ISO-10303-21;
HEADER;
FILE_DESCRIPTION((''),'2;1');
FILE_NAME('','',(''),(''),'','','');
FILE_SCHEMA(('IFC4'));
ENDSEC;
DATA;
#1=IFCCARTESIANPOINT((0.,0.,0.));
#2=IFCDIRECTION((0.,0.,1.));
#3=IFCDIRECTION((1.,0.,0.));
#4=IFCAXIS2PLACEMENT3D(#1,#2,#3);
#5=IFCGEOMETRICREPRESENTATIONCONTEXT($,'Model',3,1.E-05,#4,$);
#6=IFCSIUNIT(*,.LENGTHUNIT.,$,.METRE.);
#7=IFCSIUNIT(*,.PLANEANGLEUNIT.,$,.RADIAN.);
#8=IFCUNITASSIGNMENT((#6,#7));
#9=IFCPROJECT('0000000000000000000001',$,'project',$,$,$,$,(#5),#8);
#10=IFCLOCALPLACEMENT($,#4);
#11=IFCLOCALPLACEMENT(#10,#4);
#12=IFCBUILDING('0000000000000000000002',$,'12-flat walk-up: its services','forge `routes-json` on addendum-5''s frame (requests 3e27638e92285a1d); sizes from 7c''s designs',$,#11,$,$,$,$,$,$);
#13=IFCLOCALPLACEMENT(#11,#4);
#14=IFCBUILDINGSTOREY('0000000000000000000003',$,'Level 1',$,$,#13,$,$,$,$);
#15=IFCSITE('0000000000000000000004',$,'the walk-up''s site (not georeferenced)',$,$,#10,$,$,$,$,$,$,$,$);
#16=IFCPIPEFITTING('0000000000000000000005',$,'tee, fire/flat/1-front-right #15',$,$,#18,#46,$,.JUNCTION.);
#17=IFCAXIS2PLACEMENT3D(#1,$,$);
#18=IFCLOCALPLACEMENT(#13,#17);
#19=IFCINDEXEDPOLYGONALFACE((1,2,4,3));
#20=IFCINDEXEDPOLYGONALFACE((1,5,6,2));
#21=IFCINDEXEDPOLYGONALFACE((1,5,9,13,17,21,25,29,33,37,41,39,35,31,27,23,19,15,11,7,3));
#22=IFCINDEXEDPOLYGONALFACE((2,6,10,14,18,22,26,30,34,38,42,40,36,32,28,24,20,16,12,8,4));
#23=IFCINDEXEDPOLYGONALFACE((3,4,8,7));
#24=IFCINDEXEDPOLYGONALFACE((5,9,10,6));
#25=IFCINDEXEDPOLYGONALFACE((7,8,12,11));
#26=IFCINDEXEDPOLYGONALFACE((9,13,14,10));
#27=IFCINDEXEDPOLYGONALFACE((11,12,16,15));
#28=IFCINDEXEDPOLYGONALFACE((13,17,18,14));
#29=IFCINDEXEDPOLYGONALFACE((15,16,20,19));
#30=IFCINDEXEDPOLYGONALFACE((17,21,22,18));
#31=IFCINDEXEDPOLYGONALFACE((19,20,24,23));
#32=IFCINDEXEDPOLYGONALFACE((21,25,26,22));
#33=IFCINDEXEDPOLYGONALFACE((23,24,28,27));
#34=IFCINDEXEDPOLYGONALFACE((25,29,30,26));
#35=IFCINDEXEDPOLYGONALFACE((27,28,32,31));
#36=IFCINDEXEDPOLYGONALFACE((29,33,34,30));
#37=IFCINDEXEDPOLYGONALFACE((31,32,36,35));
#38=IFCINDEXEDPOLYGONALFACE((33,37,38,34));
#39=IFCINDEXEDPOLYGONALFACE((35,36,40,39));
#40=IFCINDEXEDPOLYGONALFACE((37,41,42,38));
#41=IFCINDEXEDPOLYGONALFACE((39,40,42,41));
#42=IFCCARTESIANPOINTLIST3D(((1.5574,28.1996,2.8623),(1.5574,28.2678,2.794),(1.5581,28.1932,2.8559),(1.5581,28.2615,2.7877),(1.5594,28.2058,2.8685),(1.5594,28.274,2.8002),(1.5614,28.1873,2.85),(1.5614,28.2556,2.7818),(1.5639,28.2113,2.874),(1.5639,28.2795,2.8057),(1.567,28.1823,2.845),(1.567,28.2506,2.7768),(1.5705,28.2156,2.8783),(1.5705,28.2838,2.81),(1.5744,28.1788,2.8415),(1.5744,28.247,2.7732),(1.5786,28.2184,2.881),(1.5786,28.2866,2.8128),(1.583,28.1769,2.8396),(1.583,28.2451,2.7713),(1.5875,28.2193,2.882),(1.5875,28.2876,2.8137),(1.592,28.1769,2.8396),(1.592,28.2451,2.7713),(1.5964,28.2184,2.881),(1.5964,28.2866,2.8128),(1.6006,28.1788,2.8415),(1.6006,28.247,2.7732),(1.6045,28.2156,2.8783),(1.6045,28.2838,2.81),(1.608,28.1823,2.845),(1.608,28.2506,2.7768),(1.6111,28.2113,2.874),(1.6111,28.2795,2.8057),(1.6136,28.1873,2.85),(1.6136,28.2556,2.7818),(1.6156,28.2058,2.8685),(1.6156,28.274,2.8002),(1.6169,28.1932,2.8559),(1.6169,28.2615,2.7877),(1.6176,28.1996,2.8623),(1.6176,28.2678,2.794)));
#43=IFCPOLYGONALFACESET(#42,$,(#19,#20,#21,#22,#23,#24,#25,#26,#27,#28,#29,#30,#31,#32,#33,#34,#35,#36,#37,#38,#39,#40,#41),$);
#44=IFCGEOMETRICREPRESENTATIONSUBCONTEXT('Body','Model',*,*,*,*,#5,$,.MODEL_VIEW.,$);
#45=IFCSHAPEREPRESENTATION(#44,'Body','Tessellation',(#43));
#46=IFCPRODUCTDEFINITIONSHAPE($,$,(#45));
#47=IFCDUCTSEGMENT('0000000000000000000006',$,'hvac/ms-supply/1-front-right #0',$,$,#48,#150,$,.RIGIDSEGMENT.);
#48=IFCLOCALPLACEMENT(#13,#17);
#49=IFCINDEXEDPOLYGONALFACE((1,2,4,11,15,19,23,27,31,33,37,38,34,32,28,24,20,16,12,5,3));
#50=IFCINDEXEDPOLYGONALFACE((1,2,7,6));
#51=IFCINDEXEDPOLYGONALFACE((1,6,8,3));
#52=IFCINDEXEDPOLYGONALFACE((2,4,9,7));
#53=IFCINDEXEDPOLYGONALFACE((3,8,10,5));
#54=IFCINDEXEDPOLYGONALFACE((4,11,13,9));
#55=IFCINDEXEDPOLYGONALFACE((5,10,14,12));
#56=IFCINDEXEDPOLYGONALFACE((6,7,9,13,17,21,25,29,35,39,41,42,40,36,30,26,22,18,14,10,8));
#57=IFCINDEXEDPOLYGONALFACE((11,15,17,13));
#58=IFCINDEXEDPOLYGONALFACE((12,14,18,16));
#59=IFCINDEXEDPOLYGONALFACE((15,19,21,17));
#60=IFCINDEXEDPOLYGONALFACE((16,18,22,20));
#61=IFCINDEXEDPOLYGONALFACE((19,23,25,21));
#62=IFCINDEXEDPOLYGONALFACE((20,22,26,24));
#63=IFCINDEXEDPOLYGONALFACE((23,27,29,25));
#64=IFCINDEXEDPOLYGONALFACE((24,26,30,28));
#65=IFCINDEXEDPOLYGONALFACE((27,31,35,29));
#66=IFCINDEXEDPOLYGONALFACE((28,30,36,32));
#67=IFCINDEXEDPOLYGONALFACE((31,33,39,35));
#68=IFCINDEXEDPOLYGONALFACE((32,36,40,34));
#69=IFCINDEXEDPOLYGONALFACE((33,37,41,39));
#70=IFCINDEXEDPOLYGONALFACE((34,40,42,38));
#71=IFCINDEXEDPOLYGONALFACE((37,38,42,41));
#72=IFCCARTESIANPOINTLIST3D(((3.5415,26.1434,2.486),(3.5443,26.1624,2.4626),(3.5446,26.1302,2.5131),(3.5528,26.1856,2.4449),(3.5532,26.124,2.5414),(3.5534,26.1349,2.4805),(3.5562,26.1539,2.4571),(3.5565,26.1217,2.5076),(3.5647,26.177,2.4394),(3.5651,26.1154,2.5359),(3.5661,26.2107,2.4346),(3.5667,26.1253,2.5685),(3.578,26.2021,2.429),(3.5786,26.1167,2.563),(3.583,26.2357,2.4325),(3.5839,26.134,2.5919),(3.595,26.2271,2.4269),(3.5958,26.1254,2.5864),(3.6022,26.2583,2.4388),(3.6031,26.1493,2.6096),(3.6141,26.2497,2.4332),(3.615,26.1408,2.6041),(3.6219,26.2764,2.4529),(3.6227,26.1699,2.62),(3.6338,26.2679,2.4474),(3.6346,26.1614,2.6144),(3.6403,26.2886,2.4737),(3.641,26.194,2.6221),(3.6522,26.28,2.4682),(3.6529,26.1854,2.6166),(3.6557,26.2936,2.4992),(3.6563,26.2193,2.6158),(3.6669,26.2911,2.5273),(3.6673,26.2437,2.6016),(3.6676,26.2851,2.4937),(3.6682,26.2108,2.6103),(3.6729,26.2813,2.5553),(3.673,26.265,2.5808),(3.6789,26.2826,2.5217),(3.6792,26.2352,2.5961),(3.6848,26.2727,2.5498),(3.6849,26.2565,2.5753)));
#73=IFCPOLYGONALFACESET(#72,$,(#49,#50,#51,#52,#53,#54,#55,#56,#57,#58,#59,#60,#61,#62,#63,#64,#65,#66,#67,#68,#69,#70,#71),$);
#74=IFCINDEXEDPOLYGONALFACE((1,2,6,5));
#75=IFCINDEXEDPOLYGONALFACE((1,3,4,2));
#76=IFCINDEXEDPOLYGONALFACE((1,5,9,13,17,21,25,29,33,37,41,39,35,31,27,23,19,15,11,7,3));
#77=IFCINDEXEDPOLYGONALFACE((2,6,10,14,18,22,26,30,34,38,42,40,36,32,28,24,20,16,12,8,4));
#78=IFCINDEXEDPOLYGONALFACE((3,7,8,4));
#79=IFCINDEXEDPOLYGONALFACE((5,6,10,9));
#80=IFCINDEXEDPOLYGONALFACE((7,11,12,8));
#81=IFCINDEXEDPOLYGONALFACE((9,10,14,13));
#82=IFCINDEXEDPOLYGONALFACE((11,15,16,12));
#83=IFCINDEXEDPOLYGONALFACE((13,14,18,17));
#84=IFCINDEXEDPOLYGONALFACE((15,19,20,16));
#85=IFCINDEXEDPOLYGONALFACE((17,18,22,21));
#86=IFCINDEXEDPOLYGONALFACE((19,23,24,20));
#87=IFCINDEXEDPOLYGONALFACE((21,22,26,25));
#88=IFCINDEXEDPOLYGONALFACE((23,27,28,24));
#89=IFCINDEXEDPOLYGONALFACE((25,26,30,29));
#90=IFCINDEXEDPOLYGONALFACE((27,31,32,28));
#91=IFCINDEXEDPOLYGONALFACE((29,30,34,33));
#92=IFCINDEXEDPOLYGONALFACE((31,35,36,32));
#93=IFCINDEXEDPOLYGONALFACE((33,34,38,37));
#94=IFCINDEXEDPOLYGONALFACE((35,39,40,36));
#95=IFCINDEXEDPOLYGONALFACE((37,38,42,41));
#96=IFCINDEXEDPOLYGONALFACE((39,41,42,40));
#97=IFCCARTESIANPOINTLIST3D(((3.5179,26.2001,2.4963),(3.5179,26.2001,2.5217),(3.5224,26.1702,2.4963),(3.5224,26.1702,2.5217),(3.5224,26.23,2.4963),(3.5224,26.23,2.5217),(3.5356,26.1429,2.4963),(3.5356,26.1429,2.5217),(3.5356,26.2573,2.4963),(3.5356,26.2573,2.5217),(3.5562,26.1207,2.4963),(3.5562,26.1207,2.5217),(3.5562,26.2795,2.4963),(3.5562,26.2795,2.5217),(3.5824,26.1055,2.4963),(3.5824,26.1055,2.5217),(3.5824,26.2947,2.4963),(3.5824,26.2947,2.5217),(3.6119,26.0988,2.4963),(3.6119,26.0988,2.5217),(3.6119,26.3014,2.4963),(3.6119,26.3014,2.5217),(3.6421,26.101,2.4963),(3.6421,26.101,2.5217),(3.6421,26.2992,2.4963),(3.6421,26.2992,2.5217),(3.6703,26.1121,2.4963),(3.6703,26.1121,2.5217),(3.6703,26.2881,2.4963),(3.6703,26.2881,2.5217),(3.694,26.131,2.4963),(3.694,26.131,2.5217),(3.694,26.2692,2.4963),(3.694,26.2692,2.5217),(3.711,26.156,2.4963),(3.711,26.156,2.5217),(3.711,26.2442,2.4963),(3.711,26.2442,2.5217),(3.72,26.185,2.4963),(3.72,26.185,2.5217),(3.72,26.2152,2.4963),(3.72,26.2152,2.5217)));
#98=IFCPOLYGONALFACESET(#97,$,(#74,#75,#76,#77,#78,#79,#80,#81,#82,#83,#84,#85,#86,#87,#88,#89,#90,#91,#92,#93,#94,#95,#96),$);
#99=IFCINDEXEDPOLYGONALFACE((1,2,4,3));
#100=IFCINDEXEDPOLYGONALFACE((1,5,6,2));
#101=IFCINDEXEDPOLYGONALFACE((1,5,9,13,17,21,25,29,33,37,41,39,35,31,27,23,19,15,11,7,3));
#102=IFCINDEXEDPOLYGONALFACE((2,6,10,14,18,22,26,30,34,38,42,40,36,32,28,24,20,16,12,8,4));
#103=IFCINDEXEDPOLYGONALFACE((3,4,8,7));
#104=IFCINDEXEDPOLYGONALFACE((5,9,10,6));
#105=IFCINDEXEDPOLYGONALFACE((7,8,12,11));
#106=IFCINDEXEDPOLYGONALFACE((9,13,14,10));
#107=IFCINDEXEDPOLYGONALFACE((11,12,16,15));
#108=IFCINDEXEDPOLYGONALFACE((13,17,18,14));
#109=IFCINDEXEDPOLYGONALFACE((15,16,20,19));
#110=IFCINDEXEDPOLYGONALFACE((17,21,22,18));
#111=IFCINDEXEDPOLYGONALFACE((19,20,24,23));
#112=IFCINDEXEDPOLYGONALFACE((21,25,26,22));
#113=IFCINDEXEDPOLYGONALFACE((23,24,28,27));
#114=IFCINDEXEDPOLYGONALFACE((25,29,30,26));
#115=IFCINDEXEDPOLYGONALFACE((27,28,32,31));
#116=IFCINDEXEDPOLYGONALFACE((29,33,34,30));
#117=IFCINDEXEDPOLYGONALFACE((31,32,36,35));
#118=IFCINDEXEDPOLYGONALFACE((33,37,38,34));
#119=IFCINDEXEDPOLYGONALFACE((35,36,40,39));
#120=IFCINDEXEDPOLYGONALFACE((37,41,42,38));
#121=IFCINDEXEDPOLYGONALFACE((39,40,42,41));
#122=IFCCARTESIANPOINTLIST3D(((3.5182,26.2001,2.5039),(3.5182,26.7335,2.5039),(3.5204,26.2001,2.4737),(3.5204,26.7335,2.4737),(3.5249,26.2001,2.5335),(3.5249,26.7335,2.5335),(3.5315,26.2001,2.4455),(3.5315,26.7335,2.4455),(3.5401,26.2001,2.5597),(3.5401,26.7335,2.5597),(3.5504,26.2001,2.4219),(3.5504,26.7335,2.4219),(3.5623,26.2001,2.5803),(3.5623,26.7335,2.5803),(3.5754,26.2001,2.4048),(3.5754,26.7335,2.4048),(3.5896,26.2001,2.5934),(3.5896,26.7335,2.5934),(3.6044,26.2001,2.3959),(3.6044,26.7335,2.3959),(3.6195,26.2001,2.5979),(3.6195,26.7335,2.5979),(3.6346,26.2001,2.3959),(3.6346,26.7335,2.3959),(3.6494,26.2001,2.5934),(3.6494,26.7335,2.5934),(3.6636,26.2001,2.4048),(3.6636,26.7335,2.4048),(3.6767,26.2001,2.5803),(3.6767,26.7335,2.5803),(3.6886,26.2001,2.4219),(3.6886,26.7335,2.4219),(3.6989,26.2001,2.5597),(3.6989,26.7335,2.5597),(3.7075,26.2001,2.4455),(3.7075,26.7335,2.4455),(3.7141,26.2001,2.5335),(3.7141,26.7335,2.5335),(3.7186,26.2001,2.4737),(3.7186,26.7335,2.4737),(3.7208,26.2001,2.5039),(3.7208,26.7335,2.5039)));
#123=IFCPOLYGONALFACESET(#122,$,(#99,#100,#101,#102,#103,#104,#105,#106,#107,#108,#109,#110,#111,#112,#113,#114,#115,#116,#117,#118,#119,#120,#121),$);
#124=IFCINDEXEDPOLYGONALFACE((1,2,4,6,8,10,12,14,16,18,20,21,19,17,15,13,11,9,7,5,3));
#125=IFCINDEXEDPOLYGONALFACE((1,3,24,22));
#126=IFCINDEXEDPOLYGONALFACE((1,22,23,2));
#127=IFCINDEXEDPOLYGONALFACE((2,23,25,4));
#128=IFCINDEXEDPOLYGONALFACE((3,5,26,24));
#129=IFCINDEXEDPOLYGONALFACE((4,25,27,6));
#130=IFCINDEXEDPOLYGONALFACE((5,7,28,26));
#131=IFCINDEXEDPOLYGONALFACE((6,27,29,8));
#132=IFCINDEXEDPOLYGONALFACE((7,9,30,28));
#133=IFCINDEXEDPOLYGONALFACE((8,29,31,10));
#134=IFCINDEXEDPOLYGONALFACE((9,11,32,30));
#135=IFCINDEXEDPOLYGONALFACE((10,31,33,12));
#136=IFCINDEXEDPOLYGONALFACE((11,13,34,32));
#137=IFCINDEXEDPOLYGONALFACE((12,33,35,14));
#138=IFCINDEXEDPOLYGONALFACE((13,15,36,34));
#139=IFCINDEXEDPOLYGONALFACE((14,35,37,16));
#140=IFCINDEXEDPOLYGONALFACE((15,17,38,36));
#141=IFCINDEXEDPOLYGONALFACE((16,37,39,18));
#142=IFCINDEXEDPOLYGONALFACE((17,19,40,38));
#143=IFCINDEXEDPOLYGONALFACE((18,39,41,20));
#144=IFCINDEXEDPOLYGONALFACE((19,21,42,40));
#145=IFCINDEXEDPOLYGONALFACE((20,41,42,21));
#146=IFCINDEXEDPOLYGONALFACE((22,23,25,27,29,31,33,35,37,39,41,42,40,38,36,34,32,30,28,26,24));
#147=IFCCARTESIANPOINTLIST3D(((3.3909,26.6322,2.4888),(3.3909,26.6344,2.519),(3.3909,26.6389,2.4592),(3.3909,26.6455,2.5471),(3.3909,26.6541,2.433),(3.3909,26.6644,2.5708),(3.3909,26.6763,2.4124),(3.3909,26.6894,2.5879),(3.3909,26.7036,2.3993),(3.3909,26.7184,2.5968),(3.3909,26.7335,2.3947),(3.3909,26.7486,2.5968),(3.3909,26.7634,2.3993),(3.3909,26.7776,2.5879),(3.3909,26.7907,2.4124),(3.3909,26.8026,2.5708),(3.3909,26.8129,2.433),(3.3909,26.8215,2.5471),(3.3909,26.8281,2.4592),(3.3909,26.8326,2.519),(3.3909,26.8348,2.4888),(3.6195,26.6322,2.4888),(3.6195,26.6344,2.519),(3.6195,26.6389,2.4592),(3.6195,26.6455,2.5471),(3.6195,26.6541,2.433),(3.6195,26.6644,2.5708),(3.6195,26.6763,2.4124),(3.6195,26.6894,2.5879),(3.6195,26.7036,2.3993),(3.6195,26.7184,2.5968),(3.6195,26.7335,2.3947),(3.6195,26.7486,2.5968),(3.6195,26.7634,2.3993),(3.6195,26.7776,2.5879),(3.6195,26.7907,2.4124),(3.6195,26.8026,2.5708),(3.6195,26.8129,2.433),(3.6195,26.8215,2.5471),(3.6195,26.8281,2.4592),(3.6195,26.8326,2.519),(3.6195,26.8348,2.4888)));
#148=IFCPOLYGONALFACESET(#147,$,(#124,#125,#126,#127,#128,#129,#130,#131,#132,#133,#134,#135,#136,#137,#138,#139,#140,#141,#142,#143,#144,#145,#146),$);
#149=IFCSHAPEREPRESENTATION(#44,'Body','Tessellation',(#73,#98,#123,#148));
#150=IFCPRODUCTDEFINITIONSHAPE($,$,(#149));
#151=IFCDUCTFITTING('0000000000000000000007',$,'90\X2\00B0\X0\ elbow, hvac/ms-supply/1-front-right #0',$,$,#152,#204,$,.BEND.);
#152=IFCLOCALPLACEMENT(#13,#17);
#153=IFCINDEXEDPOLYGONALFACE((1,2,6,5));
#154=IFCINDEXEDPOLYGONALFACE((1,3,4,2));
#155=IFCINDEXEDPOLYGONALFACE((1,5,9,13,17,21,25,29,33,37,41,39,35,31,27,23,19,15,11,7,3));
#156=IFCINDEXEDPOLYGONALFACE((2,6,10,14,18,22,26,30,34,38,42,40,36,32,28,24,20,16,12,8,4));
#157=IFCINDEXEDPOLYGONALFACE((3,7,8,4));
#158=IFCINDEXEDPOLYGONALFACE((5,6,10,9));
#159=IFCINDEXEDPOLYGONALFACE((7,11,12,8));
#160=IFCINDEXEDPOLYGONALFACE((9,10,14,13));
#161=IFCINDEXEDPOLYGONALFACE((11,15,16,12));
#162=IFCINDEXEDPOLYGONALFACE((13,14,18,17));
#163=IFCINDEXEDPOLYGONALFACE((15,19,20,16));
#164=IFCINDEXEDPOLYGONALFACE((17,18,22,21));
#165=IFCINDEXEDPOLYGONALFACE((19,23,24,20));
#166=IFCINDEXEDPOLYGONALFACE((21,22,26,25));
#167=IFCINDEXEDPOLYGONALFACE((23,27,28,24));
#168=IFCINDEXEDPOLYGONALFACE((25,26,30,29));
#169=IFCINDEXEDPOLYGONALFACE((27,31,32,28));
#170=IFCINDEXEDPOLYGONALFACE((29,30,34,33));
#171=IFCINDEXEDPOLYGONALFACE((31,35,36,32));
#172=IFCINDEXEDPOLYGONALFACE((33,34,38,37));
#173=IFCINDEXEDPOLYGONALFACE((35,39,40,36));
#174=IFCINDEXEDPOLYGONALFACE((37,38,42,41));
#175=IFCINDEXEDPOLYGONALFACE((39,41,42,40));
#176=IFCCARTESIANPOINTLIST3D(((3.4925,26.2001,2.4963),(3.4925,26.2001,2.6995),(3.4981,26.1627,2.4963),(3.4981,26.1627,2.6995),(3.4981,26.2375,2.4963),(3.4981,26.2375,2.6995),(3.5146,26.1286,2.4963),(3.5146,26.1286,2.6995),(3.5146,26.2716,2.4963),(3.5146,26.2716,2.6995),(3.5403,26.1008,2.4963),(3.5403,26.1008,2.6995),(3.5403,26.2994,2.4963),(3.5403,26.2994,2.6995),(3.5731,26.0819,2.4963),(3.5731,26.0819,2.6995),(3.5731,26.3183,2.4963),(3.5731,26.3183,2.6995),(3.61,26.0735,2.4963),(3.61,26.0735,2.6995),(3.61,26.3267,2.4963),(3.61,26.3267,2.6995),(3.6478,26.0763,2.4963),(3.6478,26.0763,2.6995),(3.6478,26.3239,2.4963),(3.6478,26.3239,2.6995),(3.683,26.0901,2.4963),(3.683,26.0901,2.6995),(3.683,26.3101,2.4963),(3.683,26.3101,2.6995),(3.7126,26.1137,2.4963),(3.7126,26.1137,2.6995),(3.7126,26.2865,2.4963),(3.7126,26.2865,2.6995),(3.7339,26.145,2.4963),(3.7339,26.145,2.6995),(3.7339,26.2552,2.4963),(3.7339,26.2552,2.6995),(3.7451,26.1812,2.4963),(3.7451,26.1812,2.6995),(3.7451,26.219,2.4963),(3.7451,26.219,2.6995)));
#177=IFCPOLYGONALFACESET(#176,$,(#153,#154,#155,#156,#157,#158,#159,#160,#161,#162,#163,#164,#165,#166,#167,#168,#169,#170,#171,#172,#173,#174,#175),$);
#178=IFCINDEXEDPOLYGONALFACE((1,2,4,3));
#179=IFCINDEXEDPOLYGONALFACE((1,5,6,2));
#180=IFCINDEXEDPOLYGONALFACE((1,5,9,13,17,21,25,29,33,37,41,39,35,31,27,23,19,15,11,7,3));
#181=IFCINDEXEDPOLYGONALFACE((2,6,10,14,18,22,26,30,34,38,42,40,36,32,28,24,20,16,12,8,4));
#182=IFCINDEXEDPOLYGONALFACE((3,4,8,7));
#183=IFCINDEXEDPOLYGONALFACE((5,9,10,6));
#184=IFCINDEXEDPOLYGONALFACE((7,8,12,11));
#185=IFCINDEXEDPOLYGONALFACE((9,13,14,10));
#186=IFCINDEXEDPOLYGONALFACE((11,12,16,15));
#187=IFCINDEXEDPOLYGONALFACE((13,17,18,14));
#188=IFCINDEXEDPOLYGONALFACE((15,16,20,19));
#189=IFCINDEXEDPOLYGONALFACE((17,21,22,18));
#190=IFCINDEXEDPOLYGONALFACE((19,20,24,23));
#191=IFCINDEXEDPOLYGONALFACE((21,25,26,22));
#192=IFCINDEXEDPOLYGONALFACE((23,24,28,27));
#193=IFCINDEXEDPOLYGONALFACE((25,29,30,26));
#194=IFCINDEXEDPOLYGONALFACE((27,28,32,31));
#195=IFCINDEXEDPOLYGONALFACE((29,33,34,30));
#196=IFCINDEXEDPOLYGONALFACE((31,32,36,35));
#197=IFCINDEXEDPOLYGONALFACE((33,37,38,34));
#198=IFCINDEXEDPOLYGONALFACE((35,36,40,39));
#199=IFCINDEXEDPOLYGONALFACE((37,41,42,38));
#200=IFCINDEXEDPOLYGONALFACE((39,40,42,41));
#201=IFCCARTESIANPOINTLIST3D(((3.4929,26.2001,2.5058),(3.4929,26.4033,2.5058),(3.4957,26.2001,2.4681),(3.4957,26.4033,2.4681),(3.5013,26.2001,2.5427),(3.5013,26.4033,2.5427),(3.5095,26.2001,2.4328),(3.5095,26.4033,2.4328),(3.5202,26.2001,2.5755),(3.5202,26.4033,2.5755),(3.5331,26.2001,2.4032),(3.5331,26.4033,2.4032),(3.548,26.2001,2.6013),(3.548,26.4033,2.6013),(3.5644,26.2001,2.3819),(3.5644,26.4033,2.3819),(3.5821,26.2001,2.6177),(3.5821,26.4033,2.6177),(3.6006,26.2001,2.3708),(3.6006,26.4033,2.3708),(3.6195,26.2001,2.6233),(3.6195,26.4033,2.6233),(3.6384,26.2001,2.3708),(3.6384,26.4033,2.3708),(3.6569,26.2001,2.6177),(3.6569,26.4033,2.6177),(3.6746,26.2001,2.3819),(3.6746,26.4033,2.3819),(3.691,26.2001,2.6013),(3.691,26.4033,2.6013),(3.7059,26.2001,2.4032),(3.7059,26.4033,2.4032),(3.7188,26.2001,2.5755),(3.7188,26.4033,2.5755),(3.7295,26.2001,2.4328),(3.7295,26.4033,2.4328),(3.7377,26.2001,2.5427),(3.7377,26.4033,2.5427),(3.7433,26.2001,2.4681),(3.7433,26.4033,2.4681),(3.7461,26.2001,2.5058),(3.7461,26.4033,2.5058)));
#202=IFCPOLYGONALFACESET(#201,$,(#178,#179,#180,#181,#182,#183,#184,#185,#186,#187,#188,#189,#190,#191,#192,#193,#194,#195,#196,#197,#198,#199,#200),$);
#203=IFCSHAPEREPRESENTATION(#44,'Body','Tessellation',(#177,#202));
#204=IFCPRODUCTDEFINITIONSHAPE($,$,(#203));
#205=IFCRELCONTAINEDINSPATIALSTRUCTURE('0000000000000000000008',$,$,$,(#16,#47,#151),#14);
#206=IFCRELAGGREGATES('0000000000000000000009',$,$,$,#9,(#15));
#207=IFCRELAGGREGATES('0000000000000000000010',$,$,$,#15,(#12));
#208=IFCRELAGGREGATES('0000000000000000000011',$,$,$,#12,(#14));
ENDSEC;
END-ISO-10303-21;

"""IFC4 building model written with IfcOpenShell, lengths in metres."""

from ifc_helpers import new_model, entity, si_unit, frame, origin_with_axes, place, context, subcontext, project, spatial, element, save


model = new_model("IFC4")

# Units and contexts
model_context = context("Model", 3, precision=1e-05, world=origin_with_axes())
body_context = subcontext(model_context, "Body", "Model", "MODEL_VIEW")
ifc_project = project(units=[si_unit("LENGTHUNIT", "METRE"), si_unit("PLANEANGLEUNIT", "RADIAN")], contexts=[model_context])

# Site, building, storey
site_placement = place(None, origin_with_axes())
site = spatial("IfcSite", under=ifc_project, at=site_placement, Name="the walk-up's site (not georeferenced)")
building_placement = place(site_placement, origin_with_axes())
building = spatial("IfcBuilding", under=site, at=building_placement, Name="12-flat walk-up: its services", Description="forge `routes-json` on addendum-5's frame (requests 3e27638e92285a1d); sizes from 7c's designs")
storey_placement = place(building_placement, origin_with_axes())
storey = spatial("IfcBuildingStorey", under=building, at=storey_placement, Name="Level 1")

# Pipe fitting
pipe_fitting_1_placement = place(storey_placement, frame((1.5875, 28.198, 2.8607), z_axis=(0.0, 0.0, 1.0), x_axis=(1.0, 0.0, 0.0)))
element("IfcPipeFitting", 1, at=pipe_fitting_1_placement, inside=storey, Name="tee, fire/flat/1-front-right #15", PredefinedType="JUNCTION", context=body_context, shape_type="AdvancedSweptSolid", body=[
    entity("IfcSweptDiskSolid", entity("IfcPolyline", [entity("IfcCartesianPoint", [0.0, 0.0, 0.0]), entity("IfcCartesianPoint", [0.0, 0.0682, -0.0682])]), 0.0302),
])

# Duct segment
duct_segment_1_placement = place(storey_placement, frame((3.6076, 26.2087, 2.5273), z_axis=(0.0, 0.0, 1.0), x_axis=(1.0, 0.0, 0.0)))
element("IfcDuctSegment", 2, at=duct_segment_1_placement, inside=storey, Name="hvac/ms-supply/1-front-right #0", PredefinedType="RIGIDSEGMENT", context=body_context, shape_type="AdvancedSweptSolid", body=[
    entity("IfcSweptDiskSolid", entity("IfcPolyline", [entity("IfcCartesianPoint", [0.0, 0.0, 0.0]), entity("IfcCartesianPoint", [0.0119, -0.0086, -0.0055])]), 0.1016),
    entity("IfcSweptDiskSolid", entity("IfcPolyline", [entity("IfcCartesianPoint", [0.0119, -0.0086, -0.0055]), entity("IfcCartesianPoint", [0.0119, -0.0086, -0.0309])]), 0.1016),
    entity("IfcSweptDiskSolid", entity("IfcPolyline", [entity("IfcCartesianPoint", [0.0119, -0.0086, -0.0309]), entity("IfcCartesianPoint", [0.0119, 0.5248, -0.0309])]), 0.1016),
    entity("IfcSweptDiskSolid", entity("IfcPolyline", [entity("IfcCartesianPoint", [0.0119, 0.5248, -0.0309]), entity("IfcCartesianPoint", [-0.2167, 0.5248, -0.0309])]), 0.1016),
])

# Duct fitting
duct_fitting_1_placement = place(storey_placement, frame((3.6195, 26.2001, 2.6995), z_axis=(0.0, 0.0, 1.0), x_axis=(1.0, 0.0, 0.0)))
element("IfcDuctFitting", 3, at=duct_fitting_1_placement, inside=storey, Name="90° elbow, hvac/ms-supply/1-front-right #0", PredefinedType="BEND", context=body_context, shape_type="AdvancedSweptSolid", body=[
    entity("IfcSweptDiskSolid", entity("IfcPolyline", [entity("IfcCartesianPoint", [0.0, 0.0, 0.0]), entity("IfcCartesianPoint", [0.0, 0.0, -0.2032])]), 0.127),
    entity("IfcSweptDiskSolid", entity("IfcPolyline", [entity("IfcCartesianPoint", [0.0, 0.0, -0.2032]), entity("IfcCartesianPoint", [0.0, 0.2032, -0.2032])]), 0.127),
])

save(model, "model.ifc")
